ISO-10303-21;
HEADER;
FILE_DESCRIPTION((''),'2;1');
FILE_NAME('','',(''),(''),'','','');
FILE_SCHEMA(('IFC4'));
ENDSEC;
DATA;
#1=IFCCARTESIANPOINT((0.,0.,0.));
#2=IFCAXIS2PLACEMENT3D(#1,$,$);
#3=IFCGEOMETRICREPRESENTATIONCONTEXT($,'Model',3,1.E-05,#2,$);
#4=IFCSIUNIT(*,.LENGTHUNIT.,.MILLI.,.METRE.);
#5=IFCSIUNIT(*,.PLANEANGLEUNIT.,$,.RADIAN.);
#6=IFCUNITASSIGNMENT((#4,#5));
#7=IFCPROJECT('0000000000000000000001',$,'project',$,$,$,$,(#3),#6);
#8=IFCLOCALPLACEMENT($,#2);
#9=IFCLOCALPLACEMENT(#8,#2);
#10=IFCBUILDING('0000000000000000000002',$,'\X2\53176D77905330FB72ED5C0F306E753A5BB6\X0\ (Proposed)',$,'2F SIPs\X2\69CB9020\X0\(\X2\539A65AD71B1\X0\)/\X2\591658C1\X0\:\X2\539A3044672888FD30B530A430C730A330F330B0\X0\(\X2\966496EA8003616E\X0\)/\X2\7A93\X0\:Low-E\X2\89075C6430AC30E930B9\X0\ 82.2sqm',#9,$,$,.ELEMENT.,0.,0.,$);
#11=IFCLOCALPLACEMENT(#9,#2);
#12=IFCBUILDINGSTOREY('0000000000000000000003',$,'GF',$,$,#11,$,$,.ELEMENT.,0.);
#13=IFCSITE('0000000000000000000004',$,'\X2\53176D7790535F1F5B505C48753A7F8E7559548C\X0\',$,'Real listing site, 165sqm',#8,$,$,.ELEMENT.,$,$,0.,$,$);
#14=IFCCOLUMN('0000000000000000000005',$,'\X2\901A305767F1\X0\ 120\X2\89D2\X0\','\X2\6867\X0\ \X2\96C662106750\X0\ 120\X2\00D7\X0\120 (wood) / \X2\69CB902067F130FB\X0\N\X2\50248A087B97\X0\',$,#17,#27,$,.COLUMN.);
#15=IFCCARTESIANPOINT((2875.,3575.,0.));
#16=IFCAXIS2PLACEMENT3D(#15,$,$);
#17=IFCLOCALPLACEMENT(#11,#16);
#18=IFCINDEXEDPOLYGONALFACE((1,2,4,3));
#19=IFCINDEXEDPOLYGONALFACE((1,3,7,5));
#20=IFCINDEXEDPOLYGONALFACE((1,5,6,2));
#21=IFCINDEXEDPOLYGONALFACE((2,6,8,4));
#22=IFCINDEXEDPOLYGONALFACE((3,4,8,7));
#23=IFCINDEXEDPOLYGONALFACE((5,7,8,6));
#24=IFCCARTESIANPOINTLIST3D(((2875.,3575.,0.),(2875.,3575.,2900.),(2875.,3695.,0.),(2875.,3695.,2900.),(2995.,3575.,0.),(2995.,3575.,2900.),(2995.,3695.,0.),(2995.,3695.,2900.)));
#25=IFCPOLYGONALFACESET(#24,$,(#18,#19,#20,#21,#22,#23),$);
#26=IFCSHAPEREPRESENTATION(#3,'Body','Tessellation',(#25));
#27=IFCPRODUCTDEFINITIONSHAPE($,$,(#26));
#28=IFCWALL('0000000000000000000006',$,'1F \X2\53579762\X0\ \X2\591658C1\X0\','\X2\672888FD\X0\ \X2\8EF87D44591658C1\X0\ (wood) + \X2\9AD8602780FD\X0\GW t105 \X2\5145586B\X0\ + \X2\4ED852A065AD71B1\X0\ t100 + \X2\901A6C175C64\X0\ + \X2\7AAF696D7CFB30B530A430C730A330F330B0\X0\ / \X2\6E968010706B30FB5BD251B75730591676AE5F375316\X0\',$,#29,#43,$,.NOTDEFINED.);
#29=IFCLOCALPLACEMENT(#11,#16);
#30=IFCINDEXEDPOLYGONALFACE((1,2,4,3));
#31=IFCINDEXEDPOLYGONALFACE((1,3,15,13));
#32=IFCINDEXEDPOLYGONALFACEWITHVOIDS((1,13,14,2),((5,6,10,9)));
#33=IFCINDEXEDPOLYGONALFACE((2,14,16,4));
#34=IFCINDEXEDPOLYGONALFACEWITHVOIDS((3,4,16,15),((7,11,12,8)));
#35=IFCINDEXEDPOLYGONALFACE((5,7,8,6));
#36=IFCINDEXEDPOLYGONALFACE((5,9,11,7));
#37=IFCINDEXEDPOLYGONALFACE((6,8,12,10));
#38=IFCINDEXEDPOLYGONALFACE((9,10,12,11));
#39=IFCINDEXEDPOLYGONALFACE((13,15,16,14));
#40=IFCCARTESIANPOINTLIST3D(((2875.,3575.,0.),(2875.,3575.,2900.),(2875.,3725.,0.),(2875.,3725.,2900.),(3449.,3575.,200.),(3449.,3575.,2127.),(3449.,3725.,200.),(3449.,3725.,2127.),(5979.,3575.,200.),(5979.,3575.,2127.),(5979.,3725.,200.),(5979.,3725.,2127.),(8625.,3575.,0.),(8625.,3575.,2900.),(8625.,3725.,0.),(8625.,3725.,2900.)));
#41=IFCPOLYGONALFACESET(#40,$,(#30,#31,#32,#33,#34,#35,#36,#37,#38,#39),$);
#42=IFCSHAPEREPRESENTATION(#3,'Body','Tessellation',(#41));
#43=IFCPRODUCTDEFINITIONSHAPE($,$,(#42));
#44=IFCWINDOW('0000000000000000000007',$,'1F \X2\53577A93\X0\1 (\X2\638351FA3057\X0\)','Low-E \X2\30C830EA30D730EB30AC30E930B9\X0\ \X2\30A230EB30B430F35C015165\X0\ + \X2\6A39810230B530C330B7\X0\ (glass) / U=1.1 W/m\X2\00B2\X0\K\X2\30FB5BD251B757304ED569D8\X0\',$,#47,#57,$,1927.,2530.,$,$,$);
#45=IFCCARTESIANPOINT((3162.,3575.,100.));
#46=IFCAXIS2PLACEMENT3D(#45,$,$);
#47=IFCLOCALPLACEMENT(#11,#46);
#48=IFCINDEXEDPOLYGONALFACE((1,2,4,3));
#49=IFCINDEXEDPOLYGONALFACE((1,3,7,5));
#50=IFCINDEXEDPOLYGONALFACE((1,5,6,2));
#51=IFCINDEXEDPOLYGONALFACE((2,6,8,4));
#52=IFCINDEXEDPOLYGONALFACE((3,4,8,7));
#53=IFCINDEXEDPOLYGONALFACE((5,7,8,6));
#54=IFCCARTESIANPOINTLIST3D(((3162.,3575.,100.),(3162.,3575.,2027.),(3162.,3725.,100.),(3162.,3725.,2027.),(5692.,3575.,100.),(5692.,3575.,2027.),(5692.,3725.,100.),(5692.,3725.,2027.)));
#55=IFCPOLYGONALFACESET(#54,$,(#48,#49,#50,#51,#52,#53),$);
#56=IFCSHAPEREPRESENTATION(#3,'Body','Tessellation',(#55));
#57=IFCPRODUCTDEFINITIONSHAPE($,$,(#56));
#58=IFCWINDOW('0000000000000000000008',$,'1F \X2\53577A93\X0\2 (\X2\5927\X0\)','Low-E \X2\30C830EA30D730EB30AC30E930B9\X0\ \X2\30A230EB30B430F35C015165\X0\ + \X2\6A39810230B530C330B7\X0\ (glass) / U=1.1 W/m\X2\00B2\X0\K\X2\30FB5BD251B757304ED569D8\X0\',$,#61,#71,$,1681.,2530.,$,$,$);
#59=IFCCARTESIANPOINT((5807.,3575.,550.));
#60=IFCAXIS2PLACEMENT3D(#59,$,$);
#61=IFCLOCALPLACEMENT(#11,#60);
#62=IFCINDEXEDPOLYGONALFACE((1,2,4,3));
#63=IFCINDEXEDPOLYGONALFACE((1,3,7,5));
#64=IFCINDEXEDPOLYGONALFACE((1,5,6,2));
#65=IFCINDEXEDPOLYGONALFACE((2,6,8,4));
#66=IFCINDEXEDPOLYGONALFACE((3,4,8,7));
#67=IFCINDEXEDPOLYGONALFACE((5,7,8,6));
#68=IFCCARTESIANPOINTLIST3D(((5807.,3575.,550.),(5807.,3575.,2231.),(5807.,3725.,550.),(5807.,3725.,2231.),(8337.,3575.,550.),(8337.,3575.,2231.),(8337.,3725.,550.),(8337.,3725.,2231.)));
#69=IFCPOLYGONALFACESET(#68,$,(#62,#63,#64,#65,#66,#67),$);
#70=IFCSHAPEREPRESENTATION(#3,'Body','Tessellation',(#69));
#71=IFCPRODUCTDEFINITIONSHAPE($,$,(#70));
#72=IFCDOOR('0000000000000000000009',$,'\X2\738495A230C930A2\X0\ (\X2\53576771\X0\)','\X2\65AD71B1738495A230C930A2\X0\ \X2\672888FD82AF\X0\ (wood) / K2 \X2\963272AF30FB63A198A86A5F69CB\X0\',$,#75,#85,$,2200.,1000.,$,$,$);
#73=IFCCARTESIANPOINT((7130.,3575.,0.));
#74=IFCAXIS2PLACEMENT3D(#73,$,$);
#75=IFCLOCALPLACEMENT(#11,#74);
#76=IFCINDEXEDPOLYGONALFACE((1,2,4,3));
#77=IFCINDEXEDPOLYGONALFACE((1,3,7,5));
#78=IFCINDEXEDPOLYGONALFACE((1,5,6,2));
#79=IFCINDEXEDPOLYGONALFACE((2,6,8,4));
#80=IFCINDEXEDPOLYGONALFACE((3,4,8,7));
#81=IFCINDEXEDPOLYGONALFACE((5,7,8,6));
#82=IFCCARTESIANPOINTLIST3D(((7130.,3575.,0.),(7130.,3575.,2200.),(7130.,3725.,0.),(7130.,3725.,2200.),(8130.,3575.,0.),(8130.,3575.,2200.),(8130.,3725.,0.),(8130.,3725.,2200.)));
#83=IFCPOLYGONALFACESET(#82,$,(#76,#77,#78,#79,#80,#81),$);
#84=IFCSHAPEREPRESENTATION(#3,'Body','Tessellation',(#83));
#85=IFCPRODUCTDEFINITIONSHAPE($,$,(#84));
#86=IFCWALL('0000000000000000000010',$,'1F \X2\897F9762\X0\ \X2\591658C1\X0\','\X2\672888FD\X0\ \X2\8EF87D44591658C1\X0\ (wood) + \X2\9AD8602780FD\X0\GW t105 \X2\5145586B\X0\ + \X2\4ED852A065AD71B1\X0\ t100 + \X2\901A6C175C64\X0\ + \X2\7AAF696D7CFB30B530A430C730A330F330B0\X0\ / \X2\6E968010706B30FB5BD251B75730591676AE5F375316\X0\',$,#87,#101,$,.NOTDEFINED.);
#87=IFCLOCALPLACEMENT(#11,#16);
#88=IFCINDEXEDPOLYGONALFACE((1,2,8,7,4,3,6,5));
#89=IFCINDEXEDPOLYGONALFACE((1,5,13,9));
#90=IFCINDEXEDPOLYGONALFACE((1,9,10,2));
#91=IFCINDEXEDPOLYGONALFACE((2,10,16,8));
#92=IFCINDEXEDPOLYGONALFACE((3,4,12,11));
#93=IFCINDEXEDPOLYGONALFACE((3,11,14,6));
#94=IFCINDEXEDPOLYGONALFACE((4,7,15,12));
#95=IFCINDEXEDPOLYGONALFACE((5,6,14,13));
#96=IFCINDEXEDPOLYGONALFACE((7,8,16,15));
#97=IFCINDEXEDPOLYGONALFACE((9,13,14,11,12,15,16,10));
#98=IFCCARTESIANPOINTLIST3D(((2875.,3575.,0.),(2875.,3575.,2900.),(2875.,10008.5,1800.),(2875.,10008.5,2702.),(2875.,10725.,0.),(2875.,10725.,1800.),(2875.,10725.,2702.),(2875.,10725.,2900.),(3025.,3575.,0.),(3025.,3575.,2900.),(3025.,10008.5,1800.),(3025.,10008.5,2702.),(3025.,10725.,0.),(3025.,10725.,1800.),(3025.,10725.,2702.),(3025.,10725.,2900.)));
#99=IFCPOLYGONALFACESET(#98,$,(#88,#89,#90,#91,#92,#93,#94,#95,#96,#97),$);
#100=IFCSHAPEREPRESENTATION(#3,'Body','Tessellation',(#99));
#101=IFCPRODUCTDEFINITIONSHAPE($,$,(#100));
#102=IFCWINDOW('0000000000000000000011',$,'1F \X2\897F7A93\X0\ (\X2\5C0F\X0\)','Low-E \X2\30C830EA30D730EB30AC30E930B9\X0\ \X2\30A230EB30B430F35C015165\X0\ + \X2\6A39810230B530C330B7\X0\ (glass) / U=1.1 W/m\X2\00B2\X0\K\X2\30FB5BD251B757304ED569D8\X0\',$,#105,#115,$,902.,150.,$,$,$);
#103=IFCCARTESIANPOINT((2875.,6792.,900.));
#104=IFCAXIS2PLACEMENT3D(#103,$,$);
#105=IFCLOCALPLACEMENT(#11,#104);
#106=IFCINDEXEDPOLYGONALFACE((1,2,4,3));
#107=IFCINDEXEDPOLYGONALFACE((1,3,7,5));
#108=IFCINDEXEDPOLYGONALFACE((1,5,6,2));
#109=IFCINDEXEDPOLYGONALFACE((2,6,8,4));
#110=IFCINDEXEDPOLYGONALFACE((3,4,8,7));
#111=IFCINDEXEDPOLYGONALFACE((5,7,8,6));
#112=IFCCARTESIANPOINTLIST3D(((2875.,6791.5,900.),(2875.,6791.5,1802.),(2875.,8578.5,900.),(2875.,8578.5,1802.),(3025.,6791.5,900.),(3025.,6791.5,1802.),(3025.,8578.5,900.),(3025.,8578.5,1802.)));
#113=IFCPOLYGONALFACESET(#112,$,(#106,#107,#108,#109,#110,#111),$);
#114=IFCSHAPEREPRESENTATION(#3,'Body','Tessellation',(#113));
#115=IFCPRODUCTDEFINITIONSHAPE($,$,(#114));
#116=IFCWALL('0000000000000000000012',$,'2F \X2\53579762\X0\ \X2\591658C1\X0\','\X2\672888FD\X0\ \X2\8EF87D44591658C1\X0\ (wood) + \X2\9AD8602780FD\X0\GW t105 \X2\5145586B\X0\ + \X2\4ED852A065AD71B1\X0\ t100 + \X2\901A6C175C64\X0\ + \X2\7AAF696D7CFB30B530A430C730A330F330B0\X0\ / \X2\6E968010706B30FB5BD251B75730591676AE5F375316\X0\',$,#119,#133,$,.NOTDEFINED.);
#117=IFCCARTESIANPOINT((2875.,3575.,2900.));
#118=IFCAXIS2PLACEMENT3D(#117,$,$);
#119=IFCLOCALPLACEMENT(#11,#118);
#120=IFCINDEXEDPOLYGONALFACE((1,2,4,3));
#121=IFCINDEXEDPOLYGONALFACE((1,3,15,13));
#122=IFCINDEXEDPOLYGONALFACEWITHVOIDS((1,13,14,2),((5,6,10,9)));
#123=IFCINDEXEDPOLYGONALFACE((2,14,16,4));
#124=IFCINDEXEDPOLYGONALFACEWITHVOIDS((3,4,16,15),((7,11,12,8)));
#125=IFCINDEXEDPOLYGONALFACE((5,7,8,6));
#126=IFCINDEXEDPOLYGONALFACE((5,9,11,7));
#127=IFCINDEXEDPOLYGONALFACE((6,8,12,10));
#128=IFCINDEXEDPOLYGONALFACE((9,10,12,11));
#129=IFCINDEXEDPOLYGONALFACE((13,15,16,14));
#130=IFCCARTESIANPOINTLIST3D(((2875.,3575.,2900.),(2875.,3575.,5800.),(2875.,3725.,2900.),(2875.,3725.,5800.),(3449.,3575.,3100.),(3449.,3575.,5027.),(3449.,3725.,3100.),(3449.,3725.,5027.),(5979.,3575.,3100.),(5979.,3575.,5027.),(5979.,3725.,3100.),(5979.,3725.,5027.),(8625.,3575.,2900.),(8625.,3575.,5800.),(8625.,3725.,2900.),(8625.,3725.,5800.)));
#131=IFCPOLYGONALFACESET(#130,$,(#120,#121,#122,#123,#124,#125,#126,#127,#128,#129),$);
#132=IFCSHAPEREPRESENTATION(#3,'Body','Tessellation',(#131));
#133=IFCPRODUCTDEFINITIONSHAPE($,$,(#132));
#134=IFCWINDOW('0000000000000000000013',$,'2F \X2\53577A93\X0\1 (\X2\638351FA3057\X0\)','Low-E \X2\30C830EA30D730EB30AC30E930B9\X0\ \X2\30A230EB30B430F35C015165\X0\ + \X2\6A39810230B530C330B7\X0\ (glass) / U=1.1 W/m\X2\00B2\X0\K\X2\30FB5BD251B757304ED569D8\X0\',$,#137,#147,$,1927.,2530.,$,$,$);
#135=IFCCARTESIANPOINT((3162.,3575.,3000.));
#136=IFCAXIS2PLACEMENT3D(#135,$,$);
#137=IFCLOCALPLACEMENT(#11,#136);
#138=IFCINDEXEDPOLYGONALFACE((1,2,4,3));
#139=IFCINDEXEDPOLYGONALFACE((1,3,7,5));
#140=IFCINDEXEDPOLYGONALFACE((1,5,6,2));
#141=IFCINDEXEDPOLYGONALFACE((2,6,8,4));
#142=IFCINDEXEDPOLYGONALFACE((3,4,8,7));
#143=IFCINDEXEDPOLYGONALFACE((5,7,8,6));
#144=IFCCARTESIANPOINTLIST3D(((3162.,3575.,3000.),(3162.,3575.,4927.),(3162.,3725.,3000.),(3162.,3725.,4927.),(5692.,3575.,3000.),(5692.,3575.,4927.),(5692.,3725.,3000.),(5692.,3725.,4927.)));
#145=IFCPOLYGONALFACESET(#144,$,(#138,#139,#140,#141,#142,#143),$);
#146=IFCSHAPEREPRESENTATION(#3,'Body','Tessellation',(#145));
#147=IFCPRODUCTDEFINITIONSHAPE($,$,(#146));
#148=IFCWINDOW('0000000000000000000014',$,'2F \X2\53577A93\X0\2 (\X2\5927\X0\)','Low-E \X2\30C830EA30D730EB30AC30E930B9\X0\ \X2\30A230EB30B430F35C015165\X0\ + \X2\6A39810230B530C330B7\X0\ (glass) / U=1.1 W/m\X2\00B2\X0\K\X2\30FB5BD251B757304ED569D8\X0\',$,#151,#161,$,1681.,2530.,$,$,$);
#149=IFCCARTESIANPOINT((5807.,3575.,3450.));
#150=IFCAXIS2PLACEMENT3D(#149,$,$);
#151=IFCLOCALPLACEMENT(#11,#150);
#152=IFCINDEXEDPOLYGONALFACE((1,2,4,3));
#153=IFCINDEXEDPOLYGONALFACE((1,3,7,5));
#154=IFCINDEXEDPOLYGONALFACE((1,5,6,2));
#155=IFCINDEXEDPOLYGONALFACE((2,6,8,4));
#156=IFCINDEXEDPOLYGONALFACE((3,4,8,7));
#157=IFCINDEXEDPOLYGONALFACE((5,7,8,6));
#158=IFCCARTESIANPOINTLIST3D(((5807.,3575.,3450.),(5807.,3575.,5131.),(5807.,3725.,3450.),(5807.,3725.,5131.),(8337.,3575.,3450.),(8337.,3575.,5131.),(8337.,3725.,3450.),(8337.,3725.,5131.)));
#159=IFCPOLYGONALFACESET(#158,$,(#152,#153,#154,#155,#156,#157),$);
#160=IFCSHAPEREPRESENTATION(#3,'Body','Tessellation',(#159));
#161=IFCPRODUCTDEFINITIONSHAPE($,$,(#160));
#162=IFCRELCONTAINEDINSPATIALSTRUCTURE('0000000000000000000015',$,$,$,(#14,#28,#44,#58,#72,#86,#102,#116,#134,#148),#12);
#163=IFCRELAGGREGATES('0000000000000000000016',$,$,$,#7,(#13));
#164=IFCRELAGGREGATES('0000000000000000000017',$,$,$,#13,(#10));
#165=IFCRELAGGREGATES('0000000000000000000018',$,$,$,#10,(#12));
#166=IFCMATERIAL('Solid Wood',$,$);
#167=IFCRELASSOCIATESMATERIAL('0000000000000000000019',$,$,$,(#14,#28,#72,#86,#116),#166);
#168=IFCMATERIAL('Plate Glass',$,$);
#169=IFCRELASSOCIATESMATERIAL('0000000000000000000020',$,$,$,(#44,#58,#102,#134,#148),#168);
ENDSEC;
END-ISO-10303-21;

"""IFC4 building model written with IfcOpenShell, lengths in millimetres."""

from ifc_helpers import new_model, si_unit, frame, frame_2d, origin, place, context, project, spatial, rectangle, extrude, material, element, fill, save


model = new_model("IFC4")

# Units and contexts
model_context = context("Model", 3, precision=1e-05, world=origin())
ifc_project = project(units=[si_unit("LENGTHUNIT", "METRE", prefix="MILLI"), si_unit("PLANEANGLEUNIT", "RADIAN")], contexts=[model_context])

# Site, building, storey
site_placement = place(None, origin())
site = spatial("IfcSite", under=ifc_project, at=site_placement, Name="北海道弟子屈町美留和", ObjectType="Real listing site, 165sqm", CompositionType="ELEMENT", RefElevation=0.0)
building_placement = place(site_placement, origin())
building = spatial("IfcBuilding", under=site, at=building_placement, Name="北海道・狭小の町家 (Proposed)", ObjectType="2F SIPs構造(厚断熱)/外壁:厚い木製サイディング(除雪考慮)/窓:Low-E複層ガラス 82.2sqm", CompositionType="ELEMENT", ElevationOfRefHeight=0.0, ElevationOfTerrain=0.0)
storey_placement = place(building_placement, origin())
storey = spatial("IfcBuildingStorey", under=building, at=storey_placement, Name="GF", CompositionType="ELEMENT", Elevation=0.0)

# Column
ifc_material_1 = material(Name="Solid Wood")
column_placement = place(storey_placement, frame((2875.0, 3575.0, 0.0)))
element("IfcColumn", 1, at=column_placement, inside=storey, material=ifc_material_1, Name="通し柱 120角", Description="桧 集成材 120×120 (wood) / 構造柱・N値計算", PredefinedType="COLUMN", context=model_context, shape_type="SweptSolid", body=[
    extrude(rectangle(XDim=120.0, YDim=120.0, at=frame_2d((60.0, 60.0))), frame((2875.0, 3575.0, 0.0)), (0.0, 0.0, 1.0), 2900.0),
])

# Wall, openings, windows, door
wall_1_placement = place(storey_placement, frame((2875.0, 3575.0, 0.0)))
wall_1 = element("IfcWall", 2, at=wall_1_placement, inside=storey, material=ifc_material_1, Name="1F 南面 外壁", Description="木製 軸組外壁 (wood) + 高性能GW t105 充填 + 付加断熱 t100 + 通気層 + 窯業系サイディング / 準耐火・寒冷地外皮強化", PredefinedType="NOTDEFINED", context=model_context, shape_type="SweptSolid", body=[
    extrude(rectangle(XDim=5750.0, YDim=150.0, at=frame_2d((2875.0, 75.0))), frame((2875.0, 3575.0, 0.0)), (0.0, 0.0, 1.0), 2900.0),
])
opening_1_placement = place(storey_placement, frame((3162.0, 3575.0, 100.0)))
opening_1 = element("IfcOpeningElement", 3, at=opening_1_placement, cuts=wall_1, PredefinedType="NOTDEFINED", context=model_context, shape_type="SweptSolid", body=[
    extrude(rectangle(XDim=2530.0, YDim=150.0, at=frame_2d((1265.0, 75.0))), frame((3162.0, 3575.0, 100.0)), (0.0, 0.0, 1.0), 1927.0),
])
opening_2_placement = place(storey_placement, frame((5807.0, 3575.0, 550.0)))
opening_2 = element("IfcOpeningElement", 4, at=opening_2_placement, cuts=wall_1, PredefinedType="NOTDEFINED", context=model_context, shape_type="SweptSolid", body=[
    extrude(rectangle(XDim=2530.0, YDim=150.0, at=frame_2d((1265.0, 75.0))), frame((5807.0, 3575.0, 550.0)), (0.0, 0.0, 1.0), 1681.0),
])
opening_3_placement = place(storey_placement, frame((7130.0, 3575.0, 0.0)))
opening_3 = element("IfcOpeningElement", 5, at=opening_3_placement, cuts=wall_1, PredefinedType="NOTDEFINED", context=model_context, shape_type="SweptSolid", body=[
    extrude(rectangle(XDim=1000.0, YDim=150.0, at=frame_2d((500.0, 75.0))), frame((7130.0, 3575.0, 0.0)), (0.0, 0.0, 1.0), 2200.0),
])
ifc_material_2 = material(Name="Plate Glass")
window_1_placement = place(storey_placement, frame((3162.0, 3575.0, 100.0)))
window_1 = element("IfcWindow", 6, at=window_1_placement, inside=storey, material=ifc_material_2, Name="1F 南窓1 (掃出し)", Description="Low-E トリプルガラス アルゴン封入 + 樹脂サッシ (glass) / U=1.1 W/m²K・寒冷地仕様", OverallHeight=1927.0, OverallWidth=2530.0, context=model_context, shape_type="SweptSolid", body=[
    extrude(rectangle(XDim=2530.0, YDim=150.0, at=frame_2d((1265.0, 75.0))), frame((3162.0, 3575.0, 100.0)), (0.0, 0.0, 1.0), 1927.0),
])
fill(opening_1, window_1)
window_2_placement = place(storey_placement, frame((5807.0, 3575.0, 550.0)))
window_2 = element("IfcWindow", 7, at=window_2_placement, inside=storey, material=ifc_material_2, Name="1F 南窓2 (大)", Description="Low-E トリプルガラス アルゴン封入 + 樹脂サッシ (glass) / U=1.1 W/m²K・寒冷地仕様", OverallHeight=1681.0, OverallWidth=2530.0, context=model_context, shape_type="SweptSolid", body=[
    extrude(rectangle(XDim=2530.0, YDim=150.0, at=frame_2d((1265.0, 75.0))), frame((5807.0, 3575.0, 550.0)), (0.0, 0.0, 1.0), 1681.0),
])
fill(opening_2, window_2)
door_placement = place(storey_placement, frame((7130.0, 3575.0, 0.0)))
door = element("IfcDoor", 8, at=door_placement, inside=storey, material=ifc_material_1, Name="玄関ドア (南東)", Description="断熱玄関ドア 木製芯 (wood) / K2 防犯・採風機構", OverallHeight=2200.0, OverallWidth=1000.0, context=model_context, shape_type="SweptSolid", body=[
    extrude(rectangle(XDim=1000.0, YDim=150.0, at=frame_2d((500.0, 75.0))), frame((7130.0, 3575.0, 0.0)), (0.0, 0.0, 1.0), 2200.0),
])
fill(opening_3, door)

# Wall, opening, window
wall_2_placement = place(storey_placement, frame((2875.0, 3575.0, 0.0)))
wall_2 = element("IfcWall", 9, at=wall_2_placement, inside=storey, material=ifc_material_1, Name="1F 西面 外壁", Description="木製 軸組外壁 (wood) + 高性能GW t105 充填 + 付加断熱 t100 + 通気層 + 窯業系サイディング / 準耐火・寒冷地外皮強化", PredefinedType="NOTDEFINED", context=model_context, shape_type="SweptSolid", body=[
    extrude(rectangle(XDim=150.0, YDim=7150.0, at=frame_2d((75.0, 3575.0))), frame((2875.0, 3575.0, 0.0)), (0.0, 0.0, 1.0), 2900.0),
])
opening_4_placement = place(storey_placement, frame((2875.0, 6792.0, 900.0)))
opening_4 = element("IfcOpeningElement", 10, at=opening_4_placement, cuts=wall_2, PredefinedType="NOTDEFINED", context=model_context, shape_type="SweptSolid", body=[
    extrude(rectangle(XDim=150.0, YDim=1787.0, at=frame_2d((75.0, 893.0))), frame((2875.0, 6792.0, 900.0)), (0.0, 0.0, 1.0), 902.0),
])
window_3_placement = place(storey_placement, frame((2875.0, 6792.0, 900.0)))
window_3 = element("IfcWindow", 11, at=window_3_placement, inside=storey, material=ifc_material_2, Name="1F 西窓 (小)", Description="Low-E トリプルガラス アルゴン封入 + 樹脂サッシ (glass) / U=1.1 W/m²K・寒冷地仕様", OverallHeight=902.0, OverallWidth=150.0, context=model_context, shape_type="SweptSolid", body=[
    extrude(rectangle(XDim=150.0, YDim=1787.0, at=frame_2d((75.0, 893.0))), frame((2875.0, 6792.0, 900.0)), (0.0, 0.0, 1.0), 902.0),
])
fill(opening_4, window_3)

# Wall, openings, windows
wall_3_placement = place(storey_placement, frame((2875.0, 3575.0, 2900.0)))
wall_3 = element("IfcWall", 12, at=wall_3_placement, inside=storey, material=ifc_material_1, Name="2F 南面 外壁", Description="木製 軸組外壁 (wood) + 高性能GW t105 充填 + 付加断熱 t100 + 通気層 + 窯業系サイディング / 準耐火・寒冷地外皮強化", PredefinedType="NOTDEFINED", context=model_context, shape_type="SweptSolid", body=[
    extrude(rectangle(XDim=5750.0, YDim=150.0, at=frame_2d((2875.0, 75.0))), frame((2875.0, 3575.0, 2900.0)), (0.0, 0.0, 1.0), 2900.0),
])
opening_5_placement = place(storey_placement, frame((3162.0, 3575.0, 3000.0)))
opening_5 = element("IfcOpeningElement", 13, at=opening_5_placement, cuts=wall_3, PredefinedType="NOTDEFINED", context=model_context, shape_type="SweptSolid", body=[
    extrude(rectangle(XDim=2530.0, YDim=150.0, at=frame_2d((1265.0, 75.0))), frame((3162.0, 3575.0, 3000.0)), (0.0, 0.0, 1.0), 1927.0),
])
opening_6_placement = place(storey_placement, frame((5807.0, 3575.0, 3450.0)))
opening_6 = element("IfcOpeningElement", 14, at=opening_6_placement, cuts=wall_3, PredefinedType="NOTDEFINED", context=model_context, shape_type="SweptSolid", body=[
    extrude(rectangle(XDim=2530.0, YDim=150.0, at=frame_2d((1265.0, 75.0))), frame((5807.0, 3575.0, 3450.0)), (0.0, 0.0, 1.0), 1681.0),
])
window_4_placement = place(storey_placement, frame((3162.0, 3575.0, 3000.0)))
window_4 = element("IfcWindow", 15, at=window_4_placement, inside=storey, material=ifc_material_2, Name="2F 南窓1 (掃出し)", Description="Low-E トリプルガラス アルゴン封入 + 樹脂サッシ (glass) / U=1.1 W/m²K・寒冷地仕様", OverallHeight=1927.0, OverallWidth=2530.0, context=model_context, shape_type="SweptSolid", body=[
    extrude(rectangle(XDim=2530.0, YDim=150.0, at=frame_2d((1265.0, 75.0))), frame((3162.0, 3575.0, 3000.0)), (0.0, 0.0, 1.0), 1927.0),
])
fill(opening_5, window_4)
window_5_placement = place(storey_placement, frame((5807.0, 3575.0, 3450.0)))
window_5 = element("IfcWindow", 16, at=window_5_placement, inside=storey, material=ifc_material_2, Name="2F 南窓2 (大)", Description="Low-E トリプルガラス アルゴン封入 + 樹脂サッシ (glass) / U=1.1 W/m²K・寒冷地仕様", OverallHeight=1681.0, OverallWidth=2530.0, context=model_context, shape_type="SweptSolid", body=[
    extrude(rectangle(XDim=2530.0, YDim=150.0, at=frame_2d((1265.0, 75.0))), frame((5807.0, 3575.0, 3450.0)), (0.0, 0.0, 1.0), 1681.0),
])
fill(opening_6, window_5)

save(model, "model.ifc")
